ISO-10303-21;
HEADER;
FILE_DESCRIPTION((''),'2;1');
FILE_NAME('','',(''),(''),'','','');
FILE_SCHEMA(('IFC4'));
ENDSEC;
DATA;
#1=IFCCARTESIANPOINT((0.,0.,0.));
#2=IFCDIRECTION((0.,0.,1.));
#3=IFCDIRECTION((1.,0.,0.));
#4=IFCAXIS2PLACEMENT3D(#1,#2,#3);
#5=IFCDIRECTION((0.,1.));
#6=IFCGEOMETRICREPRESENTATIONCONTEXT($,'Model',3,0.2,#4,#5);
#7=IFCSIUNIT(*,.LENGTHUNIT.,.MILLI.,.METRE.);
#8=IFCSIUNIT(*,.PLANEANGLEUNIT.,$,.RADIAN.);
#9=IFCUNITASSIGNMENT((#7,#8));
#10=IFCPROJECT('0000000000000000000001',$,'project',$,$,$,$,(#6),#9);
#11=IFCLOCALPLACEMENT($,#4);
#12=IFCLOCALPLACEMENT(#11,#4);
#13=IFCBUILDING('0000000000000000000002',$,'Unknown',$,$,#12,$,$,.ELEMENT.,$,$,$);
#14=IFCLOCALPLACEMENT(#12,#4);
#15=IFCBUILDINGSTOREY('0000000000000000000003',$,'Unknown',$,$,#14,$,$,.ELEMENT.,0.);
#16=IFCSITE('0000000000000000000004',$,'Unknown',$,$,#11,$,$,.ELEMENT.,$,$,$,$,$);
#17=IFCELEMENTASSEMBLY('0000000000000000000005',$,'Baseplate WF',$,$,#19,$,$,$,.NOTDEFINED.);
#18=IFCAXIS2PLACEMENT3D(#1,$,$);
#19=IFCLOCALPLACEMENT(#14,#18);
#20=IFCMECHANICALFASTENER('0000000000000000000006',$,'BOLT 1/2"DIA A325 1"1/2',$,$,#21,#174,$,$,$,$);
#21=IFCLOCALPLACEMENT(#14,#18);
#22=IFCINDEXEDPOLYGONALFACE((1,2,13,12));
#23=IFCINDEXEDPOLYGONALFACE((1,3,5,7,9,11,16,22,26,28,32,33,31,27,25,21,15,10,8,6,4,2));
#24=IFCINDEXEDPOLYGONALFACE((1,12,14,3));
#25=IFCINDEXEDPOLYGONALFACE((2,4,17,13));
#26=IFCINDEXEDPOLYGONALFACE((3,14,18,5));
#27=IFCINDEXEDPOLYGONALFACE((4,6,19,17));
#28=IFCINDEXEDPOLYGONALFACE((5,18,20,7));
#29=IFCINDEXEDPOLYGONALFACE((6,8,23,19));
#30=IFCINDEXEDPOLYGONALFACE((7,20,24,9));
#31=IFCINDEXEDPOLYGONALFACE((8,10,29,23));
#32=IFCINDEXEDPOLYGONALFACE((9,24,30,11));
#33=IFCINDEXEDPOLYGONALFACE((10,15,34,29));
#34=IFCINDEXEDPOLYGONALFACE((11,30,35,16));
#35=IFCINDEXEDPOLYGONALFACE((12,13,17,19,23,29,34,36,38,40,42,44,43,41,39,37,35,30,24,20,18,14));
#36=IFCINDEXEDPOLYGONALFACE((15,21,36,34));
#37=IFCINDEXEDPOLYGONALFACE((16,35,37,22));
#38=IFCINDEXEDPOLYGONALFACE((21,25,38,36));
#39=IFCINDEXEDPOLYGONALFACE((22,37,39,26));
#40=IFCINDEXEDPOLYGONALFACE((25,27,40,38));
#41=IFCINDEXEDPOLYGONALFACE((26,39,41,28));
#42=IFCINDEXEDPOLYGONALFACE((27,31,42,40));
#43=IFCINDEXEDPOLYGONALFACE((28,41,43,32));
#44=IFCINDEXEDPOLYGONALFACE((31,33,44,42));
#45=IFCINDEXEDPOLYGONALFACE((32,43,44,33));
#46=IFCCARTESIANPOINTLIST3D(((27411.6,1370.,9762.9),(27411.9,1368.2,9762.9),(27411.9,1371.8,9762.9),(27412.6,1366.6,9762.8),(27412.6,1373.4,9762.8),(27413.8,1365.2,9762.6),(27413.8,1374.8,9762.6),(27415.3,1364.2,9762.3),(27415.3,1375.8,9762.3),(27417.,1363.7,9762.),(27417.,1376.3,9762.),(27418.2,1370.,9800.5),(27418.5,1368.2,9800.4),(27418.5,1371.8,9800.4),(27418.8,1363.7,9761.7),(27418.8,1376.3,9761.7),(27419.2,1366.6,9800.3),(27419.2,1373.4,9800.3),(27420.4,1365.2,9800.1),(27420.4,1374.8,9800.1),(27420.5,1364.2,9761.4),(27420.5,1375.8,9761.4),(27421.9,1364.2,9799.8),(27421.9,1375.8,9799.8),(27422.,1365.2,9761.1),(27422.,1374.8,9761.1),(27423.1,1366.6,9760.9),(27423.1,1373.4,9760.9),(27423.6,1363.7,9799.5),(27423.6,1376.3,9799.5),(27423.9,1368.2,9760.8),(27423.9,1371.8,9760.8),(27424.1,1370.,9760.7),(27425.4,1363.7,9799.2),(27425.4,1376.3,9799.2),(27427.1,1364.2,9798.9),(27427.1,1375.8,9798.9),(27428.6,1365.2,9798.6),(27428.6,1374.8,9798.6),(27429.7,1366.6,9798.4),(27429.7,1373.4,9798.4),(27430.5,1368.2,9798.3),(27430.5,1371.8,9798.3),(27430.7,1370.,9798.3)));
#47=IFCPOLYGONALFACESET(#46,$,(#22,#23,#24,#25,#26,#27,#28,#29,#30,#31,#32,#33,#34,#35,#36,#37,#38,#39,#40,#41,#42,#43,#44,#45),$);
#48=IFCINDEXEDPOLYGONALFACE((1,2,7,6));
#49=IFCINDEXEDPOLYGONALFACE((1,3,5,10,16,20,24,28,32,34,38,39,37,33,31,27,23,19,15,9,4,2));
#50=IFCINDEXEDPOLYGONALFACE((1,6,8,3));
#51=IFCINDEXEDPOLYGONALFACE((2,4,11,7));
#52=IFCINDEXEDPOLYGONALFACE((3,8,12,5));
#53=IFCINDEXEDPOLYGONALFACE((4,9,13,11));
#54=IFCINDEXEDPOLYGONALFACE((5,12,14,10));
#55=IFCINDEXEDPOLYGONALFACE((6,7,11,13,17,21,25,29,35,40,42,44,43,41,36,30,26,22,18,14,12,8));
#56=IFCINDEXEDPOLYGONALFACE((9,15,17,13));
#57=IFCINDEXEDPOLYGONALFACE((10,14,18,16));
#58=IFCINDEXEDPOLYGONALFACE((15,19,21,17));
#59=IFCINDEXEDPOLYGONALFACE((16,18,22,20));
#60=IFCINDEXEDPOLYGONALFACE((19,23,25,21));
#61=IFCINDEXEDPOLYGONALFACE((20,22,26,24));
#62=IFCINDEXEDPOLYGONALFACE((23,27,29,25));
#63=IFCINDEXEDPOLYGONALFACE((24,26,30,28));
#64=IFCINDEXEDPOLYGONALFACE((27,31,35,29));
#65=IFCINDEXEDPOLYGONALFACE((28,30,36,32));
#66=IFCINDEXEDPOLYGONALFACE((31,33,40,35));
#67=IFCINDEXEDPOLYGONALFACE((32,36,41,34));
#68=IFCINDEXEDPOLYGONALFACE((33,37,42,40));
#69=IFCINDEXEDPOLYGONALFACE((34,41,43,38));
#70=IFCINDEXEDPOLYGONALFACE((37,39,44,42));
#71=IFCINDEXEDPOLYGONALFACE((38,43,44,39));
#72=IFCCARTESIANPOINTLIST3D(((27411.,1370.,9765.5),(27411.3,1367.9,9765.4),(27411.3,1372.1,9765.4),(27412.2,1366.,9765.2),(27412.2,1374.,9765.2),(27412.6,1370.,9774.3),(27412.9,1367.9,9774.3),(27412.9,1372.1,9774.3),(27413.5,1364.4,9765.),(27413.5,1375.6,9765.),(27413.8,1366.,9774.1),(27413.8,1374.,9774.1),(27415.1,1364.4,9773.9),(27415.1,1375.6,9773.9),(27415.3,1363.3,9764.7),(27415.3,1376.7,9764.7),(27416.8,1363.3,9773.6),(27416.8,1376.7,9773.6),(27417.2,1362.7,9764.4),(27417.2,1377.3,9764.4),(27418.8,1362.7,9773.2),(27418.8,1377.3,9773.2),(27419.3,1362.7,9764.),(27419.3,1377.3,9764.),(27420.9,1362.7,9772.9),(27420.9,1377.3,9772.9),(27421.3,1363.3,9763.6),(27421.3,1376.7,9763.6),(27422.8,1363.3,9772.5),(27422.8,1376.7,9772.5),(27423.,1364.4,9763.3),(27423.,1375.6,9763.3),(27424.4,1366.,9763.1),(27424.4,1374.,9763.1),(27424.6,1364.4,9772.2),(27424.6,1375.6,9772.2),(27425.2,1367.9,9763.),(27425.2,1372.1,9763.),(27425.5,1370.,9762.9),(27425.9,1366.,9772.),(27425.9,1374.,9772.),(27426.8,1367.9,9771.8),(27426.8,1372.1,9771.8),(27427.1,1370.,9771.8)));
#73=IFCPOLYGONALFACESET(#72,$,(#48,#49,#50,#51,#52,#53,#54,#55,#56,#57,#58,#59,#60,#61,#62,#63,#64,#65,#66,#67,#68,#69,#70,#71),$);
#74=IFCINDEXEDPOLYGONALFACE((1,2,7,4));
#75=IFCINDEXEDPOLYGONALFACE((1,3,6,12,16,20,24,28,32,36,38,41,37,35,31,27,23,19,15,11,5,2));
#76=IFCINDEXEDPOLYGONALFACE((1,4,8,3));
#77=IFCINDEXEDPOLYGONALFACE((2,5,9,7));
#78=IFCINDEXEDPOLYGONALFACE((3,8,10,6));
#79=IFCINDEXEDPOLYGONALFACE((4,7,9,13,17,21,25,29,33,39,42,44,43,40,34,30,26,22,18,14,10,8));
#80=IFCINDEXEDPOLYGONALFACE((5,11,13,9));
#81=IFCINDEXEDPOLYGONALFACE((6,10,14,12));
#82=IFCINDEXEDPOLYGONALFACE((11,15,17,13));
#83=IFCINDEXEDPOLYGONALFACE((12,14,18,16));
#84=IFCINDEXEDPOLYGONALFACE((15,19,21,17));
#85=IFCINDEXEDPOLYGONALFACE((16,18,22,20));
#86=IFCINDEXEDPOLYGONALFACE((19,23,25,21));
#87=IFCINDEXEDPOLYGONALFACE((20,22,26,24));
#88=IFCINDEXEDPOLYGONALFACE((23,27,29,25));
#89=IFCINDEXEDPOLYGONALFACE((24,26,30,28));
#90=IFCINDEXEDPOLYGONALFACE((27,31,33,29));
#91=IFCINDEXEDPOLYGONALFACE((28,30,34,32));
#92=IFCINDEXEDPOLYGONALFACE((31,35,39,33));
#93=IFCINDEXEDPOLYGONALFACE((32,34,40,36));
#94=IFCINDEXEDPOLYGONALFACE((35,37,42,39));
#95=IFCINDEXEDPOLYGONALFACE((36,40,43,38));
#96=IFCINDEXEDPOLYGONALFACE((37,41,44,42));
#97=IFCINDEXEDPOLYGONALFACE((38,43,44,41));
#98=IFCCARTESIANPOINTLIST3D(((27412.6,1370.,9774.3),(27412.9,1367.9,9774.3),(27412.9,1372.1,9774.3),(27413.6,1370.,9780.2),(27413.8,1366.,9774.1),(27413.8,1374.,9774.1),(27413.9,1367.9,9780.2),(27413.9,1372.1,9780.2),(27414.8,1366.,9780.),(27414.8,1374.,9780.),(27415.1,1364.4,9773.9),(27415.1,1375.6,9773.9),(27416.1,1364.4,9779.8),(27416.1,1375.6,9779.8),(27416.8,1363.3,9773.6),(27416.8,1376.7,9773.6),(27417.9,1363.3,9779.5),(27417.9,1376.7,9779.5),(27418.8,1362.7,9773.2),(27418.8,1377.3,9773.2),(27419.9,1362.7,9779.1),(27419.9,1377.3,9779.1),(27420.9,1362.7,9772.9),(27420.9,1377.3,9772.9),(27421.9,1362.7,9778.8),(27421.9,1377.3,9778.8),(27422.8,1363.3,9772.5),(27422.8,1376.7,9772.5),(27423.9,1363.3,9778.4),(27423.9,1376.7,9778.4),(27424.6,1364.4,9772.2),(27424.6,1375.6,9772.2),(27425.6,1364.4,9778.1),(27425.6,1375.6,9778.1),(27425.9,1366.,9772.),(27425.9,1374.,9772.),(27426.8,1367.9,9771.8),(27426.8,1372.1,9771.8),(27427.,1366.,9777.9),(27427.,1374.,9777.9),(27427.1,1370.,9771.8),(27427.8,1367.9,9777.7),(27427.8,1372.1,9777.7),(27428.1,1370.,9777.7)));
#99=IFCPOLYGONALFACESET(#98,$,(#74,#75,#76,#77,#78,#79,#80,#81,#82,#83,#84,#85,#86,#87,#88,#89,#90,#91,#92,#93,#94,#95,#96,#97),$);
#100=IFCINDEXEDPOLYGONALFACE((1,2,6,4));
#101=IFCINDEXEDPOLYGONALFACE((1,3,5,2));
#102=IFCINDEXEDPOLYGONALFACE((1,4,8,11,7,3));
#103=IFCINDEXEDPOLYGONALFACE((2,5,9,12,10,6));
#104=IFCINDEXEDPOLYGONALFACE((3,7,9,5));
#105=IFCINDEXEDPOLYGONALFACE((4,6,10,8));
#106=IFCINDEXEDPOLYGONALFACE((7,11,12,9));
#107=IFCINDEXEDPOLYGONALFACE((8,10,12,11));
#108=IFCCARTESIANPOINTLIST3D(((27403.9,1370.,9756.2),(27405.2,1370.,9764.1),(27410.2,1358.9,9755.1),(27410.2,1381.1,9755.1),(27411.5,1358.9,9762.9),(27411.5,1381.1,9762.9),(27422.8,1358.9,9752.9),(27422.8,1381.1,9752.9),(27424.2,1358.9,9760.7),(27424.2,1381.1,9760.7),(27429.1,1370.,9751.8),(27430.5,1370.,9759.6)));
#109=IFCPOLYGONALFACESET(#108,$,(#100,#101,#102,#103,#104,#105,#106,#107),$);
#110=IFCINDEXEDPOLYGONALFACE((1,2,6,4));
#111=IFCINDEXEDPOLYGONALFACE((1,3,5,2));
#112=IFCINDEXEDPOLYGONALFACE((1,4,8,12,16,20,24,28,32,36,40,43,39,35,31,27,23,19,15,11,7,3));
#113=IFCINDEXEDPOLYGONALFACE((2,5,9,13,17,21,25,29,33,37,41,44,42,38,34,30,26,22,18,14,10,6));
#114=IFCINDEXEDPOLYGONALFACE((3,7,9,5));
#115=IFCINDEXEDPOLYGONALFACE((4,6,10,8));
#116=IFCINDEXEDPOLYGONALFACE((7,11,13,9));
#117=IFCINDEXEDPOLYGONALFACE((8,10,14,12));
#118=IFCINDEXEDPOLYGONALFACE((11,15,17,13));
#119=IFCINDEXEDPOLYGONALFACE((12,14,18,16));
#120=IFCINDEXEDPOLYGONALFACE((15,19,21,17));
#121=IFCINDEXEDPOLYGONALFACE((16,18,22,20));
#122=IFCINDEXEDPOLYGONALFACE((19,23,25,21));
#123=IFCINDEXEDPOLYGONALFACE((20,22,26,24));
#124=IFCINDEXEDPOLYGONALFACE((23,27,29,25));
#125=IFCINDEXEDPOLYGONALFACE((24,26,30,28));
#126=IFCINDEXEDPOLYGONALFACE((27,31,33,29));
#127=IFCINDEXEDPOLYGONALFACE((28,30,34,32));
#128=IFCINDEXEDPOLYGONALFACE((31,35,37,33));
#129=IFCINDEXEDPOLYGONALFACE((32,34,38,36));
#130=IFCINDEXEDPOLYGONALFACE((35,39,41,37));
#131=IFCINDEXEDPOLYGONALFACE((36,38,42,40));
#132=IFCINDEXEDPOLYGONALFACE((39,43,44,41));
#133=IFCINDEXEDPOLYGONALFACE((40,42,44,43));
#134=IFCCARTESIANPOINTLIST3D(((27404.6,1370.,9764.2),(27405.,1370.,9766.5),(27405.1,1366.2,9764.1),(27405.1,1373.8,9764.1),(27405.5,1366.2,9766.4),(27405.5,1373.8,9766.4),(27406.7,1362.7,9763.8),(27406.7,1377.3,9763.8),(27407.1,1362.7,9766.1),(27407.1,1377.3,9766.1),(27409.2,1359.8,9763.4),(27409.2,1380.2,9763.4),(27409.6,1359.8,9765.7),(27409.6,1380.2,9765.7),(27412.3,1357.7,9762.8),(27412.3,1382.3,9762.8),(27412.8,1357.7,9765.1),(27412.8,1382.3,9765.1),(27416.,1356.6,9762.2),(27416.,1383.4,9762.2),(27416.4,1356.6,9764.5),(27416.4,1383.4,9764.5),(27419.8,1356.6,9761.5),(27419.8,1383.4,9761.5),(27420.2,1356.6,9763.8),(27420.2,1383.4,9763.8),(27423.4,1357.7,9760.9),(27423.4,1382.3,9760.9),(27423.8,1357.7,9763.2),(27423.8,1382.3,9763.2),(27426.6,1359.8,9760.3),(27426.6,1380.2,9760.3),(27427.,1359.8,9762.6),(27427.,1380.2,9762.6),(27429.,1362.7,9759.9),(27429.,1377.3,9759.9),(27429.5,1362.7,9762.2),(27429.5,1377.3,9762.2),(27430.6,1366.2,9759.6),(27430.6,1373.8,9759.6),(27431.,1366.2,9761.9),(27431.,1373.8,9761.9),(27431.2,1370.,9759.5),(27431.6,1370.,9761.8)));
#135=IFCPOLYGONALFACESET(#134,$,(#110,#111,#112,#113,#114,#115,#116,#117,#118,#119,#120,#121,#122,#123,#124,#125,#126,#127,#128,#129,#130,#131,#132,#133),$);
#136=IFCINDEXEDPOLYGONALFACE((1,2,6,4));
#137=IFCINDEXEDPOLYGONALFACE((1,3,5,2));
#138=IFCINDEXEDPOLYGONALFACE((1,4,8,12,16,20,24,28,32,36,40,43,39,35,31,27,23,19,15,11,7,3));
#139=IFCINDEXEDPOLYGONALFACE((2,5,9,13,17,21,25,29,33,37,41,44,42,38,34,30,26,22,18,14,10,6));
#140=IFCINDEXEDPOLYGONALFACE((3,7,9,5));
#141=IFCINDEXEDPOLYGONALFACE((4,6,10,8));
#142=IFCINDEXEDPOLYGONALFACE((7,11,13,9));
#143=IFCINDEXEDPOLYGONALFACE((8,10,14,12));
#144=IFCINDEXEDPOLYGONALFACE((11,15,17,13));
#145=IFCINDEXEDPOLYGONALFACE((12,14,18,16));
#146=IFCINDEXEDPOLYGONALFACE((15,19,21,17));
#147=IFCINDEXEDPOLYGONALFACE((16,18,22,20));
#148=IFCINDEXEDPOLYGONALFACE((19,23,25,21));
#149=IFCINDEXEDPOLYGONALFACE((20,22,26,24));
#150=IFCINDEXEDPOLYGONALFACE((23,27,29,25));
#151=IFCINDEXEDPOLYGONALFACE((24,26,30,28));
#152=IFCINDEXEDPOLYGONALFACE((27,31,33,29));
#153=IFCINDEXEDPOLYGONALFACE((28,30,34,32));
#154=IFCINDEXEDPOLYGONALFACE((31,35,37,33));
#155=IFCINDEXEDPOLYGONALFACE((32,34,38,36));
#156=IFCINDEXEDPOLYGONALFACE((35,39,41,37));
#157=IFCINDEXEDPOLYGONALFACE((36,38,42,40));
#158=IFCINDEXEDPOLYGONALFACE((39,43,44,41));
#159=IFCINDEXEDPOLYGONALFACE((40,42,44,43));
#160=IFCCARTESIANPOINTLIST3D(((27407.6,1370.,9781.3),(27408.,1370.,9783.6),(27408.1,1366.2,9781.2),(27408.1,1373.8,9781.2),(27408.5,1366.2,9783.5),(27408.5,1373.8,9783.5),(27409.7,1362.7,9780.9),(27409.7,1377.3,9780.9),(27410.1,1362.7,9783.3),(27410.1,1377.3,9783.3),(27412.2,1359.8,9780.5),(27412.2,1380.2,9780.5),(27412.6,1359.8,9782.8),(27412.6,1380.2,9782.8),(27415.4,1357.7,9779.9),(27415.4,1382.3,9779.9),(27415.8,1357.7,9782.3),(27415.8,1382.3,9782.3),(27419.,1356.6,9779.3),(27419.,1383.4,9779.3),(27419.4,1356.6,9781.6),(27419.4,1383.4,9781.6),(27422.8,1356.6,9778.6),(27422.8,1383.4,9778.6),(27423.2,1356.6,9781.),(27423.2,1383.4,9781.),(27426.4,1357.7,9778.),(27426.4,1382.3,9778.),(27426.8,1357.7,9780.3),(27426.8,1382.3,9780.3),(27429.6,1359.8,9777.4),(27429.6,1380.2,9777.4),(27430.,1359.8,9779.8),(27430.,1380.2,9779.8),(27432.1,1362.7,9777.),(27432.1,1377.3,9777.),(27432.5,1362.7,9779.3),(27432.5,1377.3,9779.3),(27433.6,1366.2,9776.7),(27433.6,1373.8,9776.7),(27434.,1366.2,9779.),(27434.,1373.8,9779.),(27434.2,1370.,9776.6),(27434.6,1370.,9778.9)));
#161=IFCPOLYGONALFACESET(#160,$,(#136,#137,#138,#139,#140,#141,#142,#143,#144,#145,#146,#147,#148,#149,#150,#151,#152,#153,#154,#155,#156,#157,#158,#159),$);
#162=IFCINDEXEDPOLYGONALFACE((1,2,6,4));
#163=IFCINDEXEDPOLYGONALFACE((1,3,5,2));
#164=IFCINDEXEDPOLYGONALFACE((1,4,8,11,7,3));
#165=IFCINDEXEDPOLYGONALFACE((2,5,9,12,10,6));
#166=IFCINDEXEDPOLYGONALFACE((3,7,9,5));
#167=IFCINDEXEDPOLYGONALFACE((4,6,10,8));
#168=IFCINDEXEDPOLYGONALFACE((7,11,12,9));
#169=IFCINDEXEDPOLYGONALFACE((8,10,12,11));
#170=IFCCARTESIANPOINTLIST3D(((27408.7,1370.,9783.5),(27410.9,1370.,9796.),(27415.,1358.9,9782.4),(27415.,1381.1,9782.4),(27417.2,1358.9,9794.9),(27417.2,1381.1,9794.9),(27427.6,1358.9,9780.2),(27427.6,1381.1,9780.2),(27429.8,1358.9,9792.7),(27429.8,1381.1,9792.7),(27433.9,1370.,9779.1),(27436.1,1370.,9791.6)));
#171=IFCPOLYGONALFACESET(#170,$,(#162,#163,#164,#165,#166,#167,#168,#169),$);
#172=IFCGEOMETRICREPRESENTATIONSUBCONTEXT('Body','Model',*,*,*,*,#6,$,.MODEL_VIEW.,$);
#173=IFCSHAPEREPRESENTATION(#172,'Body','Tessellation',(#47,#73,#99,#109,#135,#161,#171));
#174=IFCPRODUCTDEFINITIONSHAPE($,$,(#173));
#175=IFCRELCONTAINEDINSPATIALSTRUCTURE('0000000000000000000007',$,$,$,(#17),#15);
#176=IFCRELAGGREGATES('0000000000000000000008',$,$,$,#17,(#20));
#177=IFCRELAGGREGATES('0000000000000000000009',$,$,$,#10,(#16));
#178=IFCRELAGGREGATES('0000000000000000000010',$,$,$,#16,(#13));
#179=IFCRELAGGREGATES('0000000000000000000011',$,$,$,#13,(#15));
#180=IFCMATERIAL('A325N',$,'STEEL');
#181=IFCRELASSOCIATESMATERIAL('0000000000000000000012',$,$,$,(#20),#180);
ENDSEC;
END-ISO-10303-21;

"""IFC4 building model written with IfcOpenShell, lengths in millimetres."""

from ifc_helpers import new_model, si_unit, direction, frame, origin_with_axes, place, context, subcontext, project, spatial, line, arc, indexed_curve, outline, extrude, source, transform, mapped, material, element, aggregate, save


model = new_model("IFC4")

# Units and contexts
model_context = context("Model", 3, precision=0.2, world=origin_with_axes(), true_north=direction((0.0, 1.0)))
body_context = subcontext(model_context, "Body", "Model", "MODEL_VIEW")
ifc_project = project(units=[si_unit("LENGTHUNIT", "METRE", prefix="MILLI"), si_unit("PLANEANGLEUNIT", "RADIAN")], contexts=[model_context])

# Site, building, storey
site_placement = place(None, origin_with_axes())
site = spatial("IfcSite", under=ifc_project, at=site_placement, Name="Unknown", CompositionType="ELEMENT")
building_placement = place(site_placement, origin_with_axes())
building = spatial("IfcBuilding", under=site, at=building_placement, Name="Unknown", CompositionType="ELEMENT")
storey_placement = place(building_placement, origin_with_axes())
storey = spatial("IfcBuildingStorey", under=building, at=storey_placement, Name="Unknown", CompositionType="ELEMENT", Elevation=0.0)

# Element assembly
assembly_1_placement = place(storey_placement, frame((27449.9, 1400.0, 9770.8), z_axis=(-0.173648, 0.0, -0.984808), x_axis=(0.0, -1.0, 0.0)))
assembly_1 = element("IfcElementAssembly", 1, at=assembly_1_placement, inside=storey, Name="Baseplate WF", PredefinedType="NOTDEFINED")

# Mechanical fastener
ifc_material_1 = material(Name="A325N", Category="STEEL")
shared_shape = source(origin_with_axes(), body_context, "Body", "SweptSolid", [
    extrude(outline(indexed_curve([(6.3, 0.0), (0.0, 6.3), (-6.3, 0.0), (0.0, -6.3)], segments=[arc(1, 2, 3), arc(3, 4, 1)])), frame((0.0, 0.0, 17.4), z_axis=(0.0, 0.0, -1.0), x_axis=(0.0, 1.0, 0.0)), (0.0, 0.0, 1.0), 38.1),
    extrude(outline(indexed_curve([(7.3, 0.0), (0.0, 7.3), (-7.3, 0.0), (0.0, -7.3)], segments=[arc(1, 2, 3), arc(3, 4, 1)])), frame((0.0, 0.0, 15.0), z_axis=(0.0, 0.0, -1.0), x_axis=(0.0, 1.0, 0.0)), (0.0, 0.0, 1.0), 9.0),
    extrude(outline(indexed_curve([(7.3, 0.0), (0.0, 7.3), (-7.3, 0.0), (0.0, -7.3)], segments=[arc(1, 2, 3), arc(3, 4, 1)])), frame((0.0, 0.0, 6.0), z_axis=(0.0, 0.0, -1.0), x_axis=(0.0, 1.0, 0.0)), (0.0, 0.0, 1.0), 6.0),
    extrude(outline(indexed_curve([(12.8, 0.0), (6.4, 11.1), (-6.4, 11.1), (-12.8, 0.0), (-6.4, -11.1), (6.4, -11.1)], segments=[line(1, 2, 3, 4, 5, 6, 1)])), frame((0.0, 0.0, 25.3), z_axis=(0.0, 0.0, -1.0), x_axis=(0.0, 1.0, 0.0)), (0.0, 0.0, 1.0), 7.9),
    extrude(outline(indexed_curve([(13.5, 0.0), (0.0, 13.5), (-13.5, 0.0), (0.0, -13.5)], segments=[arc(1, 2, 3), arc(3, 4, 1)])), frame((0.0, 0.0, 17.4), z_axis=(0.0, 0.0, -1.0), x_axis=(0.0, 1.0, 0.0)), (0.0, 0.0, 1.0), 2.4),
    extrude(outline(indexed_curve([(13.5, 0.0), (0.0, 13.5), (-13.5, 0.0), (0.0, -13.5)], segments=[arc(1, 2, 3), arc(3, 4, 1)])), frame((0.0, 0.0, 0.0), z_axis=(0.0, 0.0, -1.0), x_axis=(0.0, 1.0, 0.0)), (0.0, 0.0, 1.0), 2.4),
    extrude(outline(indexed_curve([(12.8, 0.0), (6.4, 11.1), (-6.4, 11.1), (-12.8, 0.0), (-6.4, -11.1), (6.4, -11.1)], segments=[line(1, 2, 3, 4, 5, 6, 1)])), frame((0.0, 0.0, -2.4), z_axis=(0.0, 0.0, -1.0), x_axis=(0.0, 1.0, 0.0)), (0.0, 0.0, 1.0), 12.7),
])
mechanical_fastener_1_placement = place(assembly_1_placement, frame((30.0, 30.0, -3.0), z_axis=(0.0, 0.0, 1.0), x_axis=(1.0, 0.0, 0.0)))
mechanical_fastener_1 = element("IfcMechanicalFastener", 2, at=mechanical_fastener_1_placement, material=ifc_material_1, Name="BOLT 1/2\"DIA A325 1\"1/2", context=body_context, shape_type="MappedRepresentation", body=[
    mapped(shared_shape, transform((0.0, 0.0, 0.0))),
])
aggregate(assembly_1, [mechanical_fastener_1])

save(model, "model.ifc")
